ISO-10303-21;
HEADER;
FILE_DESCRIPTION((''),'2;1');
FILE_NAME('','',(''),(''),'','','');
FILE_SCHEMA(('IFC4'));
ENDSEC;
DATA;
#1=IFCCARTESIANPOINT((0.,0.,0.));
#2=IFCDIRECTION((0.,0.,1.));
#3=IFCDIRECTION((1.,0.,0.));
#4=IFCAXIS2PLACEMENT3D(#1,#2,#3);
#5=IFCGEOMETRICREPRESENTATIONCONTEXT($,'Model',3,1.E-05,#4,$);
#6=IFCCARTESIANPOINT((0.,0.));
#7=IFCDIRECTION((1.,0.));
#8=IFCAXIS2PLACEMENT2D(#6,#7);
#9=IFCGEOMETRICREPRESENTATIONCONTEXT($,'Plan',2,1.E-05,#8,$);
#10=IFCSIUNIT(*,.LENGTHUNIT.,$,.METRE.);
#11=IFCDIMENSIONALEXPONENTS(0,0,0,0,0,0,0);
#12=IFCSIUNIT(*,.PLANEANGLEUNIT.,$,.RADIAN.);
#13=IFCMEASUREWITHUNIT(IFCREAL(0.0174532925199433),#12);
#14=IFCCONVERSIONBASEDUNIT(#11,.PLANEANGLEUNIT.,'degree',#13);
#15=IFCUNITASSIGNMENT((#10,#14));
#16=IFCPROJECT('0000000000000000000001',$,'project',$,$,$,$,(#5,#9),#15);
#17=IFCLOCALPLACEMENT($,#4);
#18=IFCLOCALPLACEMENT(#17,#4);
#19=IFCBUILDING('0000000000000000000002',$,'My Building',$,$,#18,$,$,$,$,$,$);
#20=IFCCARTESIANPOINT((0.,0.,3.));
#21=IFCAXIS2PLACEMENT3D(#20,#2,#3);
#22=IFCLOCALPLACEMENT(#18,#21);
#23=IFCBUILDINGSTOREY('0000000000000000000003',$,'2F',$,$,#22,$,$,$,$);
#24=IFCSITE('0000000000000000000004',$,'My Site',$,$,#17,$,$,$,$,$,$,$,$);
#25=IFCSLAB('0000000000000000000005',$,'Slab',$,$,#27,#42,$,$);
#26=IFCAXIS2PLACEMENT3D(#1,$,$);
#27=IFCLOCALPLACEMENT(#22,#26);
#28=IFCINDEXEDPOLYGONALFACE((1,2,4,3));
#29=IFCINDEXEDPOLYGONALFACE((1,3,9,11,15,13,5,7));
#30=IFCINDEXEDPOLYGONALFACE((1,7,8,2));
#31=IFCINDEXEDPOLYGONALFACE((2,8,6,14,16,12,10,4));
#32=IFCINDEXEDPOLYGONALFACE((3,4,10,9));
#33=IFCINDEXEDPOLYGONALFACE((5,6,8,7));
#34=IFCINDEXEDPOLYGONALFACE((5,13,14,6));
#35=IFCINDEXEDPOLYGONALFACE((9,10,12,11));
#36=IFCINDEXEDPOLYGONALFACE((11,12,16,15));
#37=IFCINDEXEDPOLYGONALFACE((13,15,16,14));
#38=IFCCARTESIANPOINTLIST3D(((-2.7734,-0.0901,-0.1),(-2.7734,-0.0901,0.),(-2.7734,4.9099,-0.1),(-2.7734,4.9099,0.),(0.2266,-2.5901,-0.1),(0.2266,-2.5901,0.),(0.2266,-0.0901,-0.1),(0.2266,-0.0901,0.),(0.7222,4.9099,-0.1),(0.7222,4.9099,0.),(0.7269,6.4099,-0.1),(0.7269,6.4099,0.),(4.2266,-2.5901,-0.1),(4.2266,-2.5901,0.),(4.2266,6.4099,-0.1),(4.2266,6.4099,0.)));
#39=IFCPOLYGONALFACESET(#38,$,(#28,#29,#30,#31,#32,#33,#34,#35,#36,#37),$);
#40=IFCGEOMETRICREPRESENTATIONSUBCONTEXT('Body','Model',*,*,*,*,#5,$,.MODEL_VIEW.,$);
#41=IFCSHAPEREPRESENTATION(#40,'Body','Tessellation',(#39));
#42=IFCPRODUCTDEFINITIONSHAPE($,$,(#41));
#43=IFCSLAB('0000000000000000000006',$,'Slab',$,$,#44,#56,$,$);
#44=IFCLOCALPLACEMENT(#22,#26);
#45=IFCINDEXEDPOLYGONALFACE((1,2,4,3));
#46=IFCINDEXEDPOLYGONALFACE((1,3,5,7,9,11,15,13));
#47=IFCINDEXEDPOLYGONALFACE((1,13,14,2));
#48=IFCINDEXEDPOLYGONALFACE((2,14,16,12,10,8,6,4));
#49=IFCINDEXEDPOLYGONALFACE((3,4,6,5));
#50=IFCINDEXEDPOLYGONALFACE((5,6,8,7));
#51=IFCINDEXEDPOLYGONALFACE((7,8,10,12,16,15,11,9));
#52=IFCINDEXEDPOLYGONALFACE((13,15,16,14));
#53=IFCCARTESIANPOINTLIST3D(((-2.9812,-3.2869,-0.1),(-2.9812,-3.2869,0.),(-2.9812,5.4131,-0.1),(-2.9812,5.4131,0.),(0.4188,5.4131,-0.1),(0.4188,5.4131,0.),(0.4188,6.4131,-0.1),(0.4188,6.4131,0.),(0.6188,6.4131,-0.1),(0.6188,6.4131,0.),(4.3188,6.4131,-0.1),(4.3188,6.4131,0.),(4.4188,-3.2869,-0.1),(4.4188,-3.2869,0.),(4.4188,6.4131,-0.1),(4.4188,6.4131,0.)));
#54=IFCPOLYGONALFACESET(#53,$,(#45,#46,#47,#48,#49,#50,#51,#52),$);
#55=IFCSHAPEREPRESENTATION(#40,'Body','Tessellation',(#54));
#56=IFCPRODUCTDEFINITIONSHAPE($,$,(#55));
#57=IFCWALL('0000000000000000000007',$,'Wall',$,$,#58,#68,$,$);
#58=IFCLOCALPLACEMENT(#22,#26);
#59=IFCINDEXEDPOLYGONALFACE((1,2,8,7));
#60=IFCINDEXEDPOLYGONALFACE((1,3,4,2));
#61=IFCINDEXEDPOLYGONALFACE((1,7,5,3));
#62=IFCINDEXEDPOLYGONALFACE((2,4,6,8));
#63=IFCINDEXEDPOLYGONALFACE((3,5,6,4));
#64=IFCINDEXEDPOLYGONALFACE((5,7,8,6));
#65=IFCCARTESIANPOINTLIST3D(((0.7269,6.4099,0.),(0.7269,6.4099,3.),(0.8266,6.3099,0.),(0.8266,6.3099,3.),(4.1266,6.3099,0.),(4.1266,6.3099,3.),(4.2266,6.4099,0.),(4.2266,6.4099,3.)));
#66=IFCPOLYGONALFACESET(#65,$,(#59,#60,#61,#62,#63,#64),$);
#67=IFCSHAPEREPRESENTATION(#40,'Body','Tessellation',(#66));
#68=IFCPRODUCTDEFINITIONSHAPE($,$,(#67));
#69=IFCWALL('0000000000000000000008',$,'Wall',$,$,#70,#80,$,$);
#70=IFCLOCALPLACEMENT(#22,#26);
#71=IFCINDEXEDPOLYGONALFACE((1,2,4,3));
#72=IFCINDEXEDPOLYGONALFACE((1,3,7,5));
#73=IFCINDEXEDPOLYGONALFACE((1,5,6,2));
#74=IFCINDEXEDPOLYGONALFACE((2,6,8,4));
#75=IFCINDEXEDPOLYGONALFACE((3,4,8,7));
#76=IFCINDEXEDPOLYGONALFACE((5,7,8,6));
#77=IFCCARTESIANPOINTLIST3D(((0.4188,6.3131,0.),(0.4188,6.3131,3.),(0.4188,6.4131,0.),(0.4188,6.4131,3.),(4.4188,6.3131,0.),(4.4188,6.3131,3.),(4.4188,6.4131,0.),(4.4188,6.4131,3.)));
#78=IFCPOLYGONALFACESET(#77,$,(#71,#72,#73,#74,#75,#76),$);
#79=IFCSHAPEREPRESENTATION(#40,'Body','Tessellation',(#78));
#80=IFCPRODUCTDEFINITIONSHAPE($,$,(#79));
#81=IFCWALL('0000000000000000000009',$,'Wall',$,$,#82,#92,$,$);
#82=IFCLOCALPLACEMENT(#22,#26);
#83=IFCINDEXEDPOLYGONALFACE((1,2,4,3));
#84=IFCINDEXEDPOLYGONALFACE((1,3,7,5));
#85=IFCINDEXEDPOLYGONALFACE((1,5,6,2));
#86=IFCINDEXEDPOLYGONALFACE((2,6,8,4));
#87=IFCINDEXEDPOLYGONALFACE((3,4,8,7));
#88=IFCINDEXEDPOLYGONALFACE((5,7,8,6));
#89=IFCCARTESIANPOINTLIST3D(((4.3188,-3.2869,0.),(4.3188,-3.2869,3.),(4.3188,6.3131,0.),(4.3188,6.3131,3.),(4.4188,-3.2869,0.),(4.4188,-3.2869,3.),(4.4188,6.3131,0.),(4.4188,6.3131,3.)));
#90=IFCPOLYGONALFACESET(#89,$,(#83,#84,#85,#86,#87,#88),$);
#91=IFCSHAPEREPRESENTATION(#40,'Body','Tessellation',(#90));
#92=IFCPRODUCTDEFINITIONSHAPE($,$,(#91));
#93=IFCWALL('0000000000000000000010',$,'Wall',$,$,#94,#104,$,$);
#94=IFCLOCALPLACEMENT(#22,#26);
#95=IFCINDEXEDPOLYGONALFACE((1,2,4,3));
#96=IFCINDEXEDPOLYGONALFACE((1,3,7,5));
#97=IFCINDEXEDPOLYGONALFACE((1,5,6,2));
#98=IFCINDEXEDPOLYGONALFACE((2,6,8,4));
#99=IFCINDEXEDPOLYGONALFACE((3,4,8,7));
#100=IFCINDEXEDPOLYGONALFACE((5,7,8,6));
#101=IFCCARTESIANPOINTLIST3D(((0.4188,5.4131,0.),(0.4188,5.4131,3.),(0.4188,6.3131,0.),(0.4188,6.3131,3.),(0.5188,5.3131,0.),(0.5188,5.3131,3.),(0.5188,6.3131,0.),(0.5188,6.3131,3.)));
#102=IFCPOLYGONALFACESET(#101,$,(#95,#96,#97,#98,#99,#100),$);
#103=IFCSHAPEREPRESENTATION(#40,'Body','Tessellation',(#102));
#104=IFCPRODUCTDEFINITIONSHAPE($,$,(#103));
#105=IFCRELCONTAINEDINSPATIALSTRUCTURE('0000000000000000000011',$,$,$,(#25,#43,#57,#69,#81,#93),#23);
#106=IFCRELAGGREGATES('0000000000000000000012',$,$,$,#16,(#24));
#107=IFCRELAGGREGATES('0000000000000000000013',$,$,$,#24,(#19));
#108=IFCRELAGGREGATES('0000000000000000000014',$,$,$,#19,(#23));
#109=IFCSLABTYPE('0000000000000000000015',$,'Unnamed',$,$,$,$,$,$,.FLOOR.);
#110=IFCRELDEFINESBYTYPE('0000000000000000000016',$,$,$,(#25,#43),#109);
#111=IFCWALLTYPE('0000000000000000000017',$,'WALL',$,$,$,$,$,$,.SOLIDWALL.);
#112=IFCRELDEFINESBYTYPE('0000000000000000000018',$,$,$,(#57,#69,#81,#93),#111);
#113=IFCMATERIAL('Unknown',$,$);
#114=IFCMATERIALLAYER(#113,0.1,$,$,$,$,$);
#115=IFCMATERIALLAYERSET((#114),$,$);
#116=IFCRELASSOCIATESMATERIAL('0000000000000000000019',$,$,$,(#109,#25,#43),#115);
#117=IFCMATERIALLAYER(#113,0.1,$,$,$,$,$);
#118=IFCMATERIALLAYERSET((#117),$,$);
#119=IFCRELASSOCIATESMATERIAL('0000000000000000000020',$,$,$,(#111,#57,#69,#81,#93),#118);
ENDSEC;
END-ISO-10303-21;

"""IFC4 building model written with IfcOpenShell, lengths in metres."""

from ifc_helpers import new_model, entity, si_unit, converted_unit, frame, origin_with_axes, origin_2d_with_axis, place, context, subcontext, project, spatial, line, indexed_curve, outline, extrude, material, layer, layer_set, layer_usage, type_object, element, save


model = new_model("IFC4")

# Units and contexts
model_context = context("Model", 3, precision=1e-05, world=origin_with_axes())
plan_context = context("Plan", 2, precision=1e-05, world=origin_2d_with_axis())
body_context_1 = subcontext(model_context, "Body", "Model", "MODEL_VIEW")
ifc_project = project(units=[si_unit("LENGTHUNIT", "METRE"), converted_unit("PLANEANGLEUNIT", "degree", entity("IfcReal", 0.0174532925199433), si_unit("PLANEANGLEUNIT", "RADIAN"), dimensions=[0, 0, 0, 0, 0, 0, 0])], contexts=[model_context, plan_context])

# Site, building, storey
site_placement = place(None, origin_with_axes())
site = spatial("IfcSite", under=ifc_project, at=site_placement, Name="My Site")
building_placement = place(site_placement, origin_with_axes())
building = spatial("IfcBuilding", under=site, at=building_placement, Name="My Building")
storey_placement = place(building_placement, frame((0.0, 0.0, 3.0), z_axis=(0.0, 0.0, 1.0), x_axis=(1.0, 0.0, 0.0)))
storey = spatial("IfcBuildingStorey", under=building, at=storey_placement, Name="2F")

# Slabs
ifc_material = material(Name="Unknown")
ifc_layer_1 = layer(ifc_material, 0.1)
ifc_layer_set_1 = layer_set([ifc_layer_1])
ifc_layer_usage_1 = layer_usage(ifc_layer_set_1, "AXIS3", "POSITIVE", -0.1)
slab_type = type_object("IfcSlabType", Name="Unnamed", PredefinedType="FLOOR", material=ifc_layer_set_1)
slab_1_placement = place(storey_placement, frame((-2.7734, 4.9099, 0.0), z_axis=(0.0, 0.0, 1.0), x_axis=(1.0, 0.0, 0.0)))
element("IfcSlab", 1, at=slab_1_placement, inside=storey, type_object=slab_type, material=ifc_layer_usage_1, Name="Slab", context=body_context_1, shape_type="SweptSolid", body=[
    extrude(outline(indexed_curve([(0.0, 0.0), (3.4956, 0.0), (3.5003, 1.5), (7.0, 1.5), (7.0, -7.5), (3.0, -7.5), (3.0, -5.0), (0.0, -5.0), (0.0, 0.0)])), frame((0.0, 0.0, -0.1), z_axis=(0.0, 0.0, 1.0), x_axis=(1.0, 0.0, 0.0)), (0.0, 0.0, 1.0), 0.1),
])
ifc_layer_usage_2 = layer_usage(ifc_layer_set_1, "AXIS3", "POSITIVE", -0.1)
slab_2_placement = place(storey_placement, frame((0.6188, 6.4131, 0.0), z_axis=(0.0, 0.0, 1.0), x_axis=(1.0, 0.0, 0.0)))
element("IfcSlab", 2, at=slab_2_placement, inside=storey, type_object=slab_type, material=ifc_layer_usage_2, Name="Slab", context=body_context_1, shape_type="SweptSolid", body=[
    extrude(outline(indexed_curve([(0.0, 0.0), (3.7, 0.0), (3.8, 0.0), (3.8, -9.7), (-3.6, -9.7), (-3.6, -1.0), (-0.2, -1.0), (-0.2, 0.0), (0.0, 0.0)])), frame((0.0, 0.0, -0.1), z_axis=(0.0, 0.0, 1.0), x_axis=(1.0, 0.0, 0.0)), (0.0, 0.0, 1.0), 0.1),
])

# Walls
ifc_layer_2 = layer(ifc_material, 0.1)
ifc_layer_set_2 = layer_set([ifc_layer_2])
ifc_layer_usage_3 = layer_usage(ifc_layer_set_2, "AXIS2", "POSITIVE", 0.0)
wall_type = type_object("IfcWallType", Name="WALL", PredefinedType="SOLIDWALL", material=ifc_layer_set_2)
wall_1_placement = place(storey_placement, frame((0.8266, 6.3099, 0.0), z_axis=(0.0, 0.0, 1.0), x_axis=(1.0, 0.0, 0.0)))
element("IfcWall", 3, at=wall_1_placement, inside=storey, type_object=wall_type, material=ifc_layer_usage_3, Name="Wall", context=body_context_1, shape_type="SweptSolid", body=[
    extrude(outline(indexed_curve([(0.0, 0.0), (-0.0997, 0.1), (3.4, 0.1), (3.3, 0.0)], segments=[line(1, 2, 3, 4, 1)])), origin_with_axes(), (0.0, 0.0, 1.0), 3.0),
])
ifc_layer_usage_4 = layer_usage(ifc_layer_set_2, "AXIS2", "POSITIVE", 0.0)
wall_2_placement = place(storey_placement, frame((0.4188, 6.3131, 0.0), z_axis=(0.0, 0.0, 1.0), x_axis=(1.0, 0.0, 0.0)))
element("IfcWall", 4, at=wall_2_placement, inside=storey, type_object=wall_type, material=ifc_layer_usage_4, Name="Wall", context=body_context_1, shape_type="SweptSolid", body=[
    extrude(outline(indexed_curve([(0.0, 0.0), (0.0, 0.1), (4.0, 0.1), (4.0, 0.0)], segments=[line(1, 2, 3, 4, 1)])), origin_with_axes(), (0.0, 0.0, 1.0), 3.0),
])
ifc_layer_usage_5 = layer_usage(ifc_layer_set_2, "AXIS2", "POSITIVE", 0.0)
wall_3_placement = place(storey_placement, frame((4.3188, 6.3131, 0.0), z_axis=(0.0, 0.0, 1.0), x_axis=(0.0, -1.0, 0.0)))
element("IfcWall", 5, at=wall_3_placement, inside=storey, type_object=wall_type, material=ifc_layer_usage_5, Name="Wall", context=body_context_1, shape_type="SweptSolid", body=[
    extrude(outline(indexed_curve([(0.0, 0.0), (0.0, 0.1), (9.6, 0.1), (9.6, 0.0)], segments=[line(1, 2, 3, 4, 1)])), origin_with_axes(), (0.0, 0.0, 1.0), 3.0),
])
ifc_layer_usage_6 = layer_usage(ifc_layer_set_2, "AXIS2", "POSITIVE", 0.0)
wall_4_placement = place(storey_placement, frame((0.4188, 6.3131, 0.0), z_axis=(0.0, 0.0, 1.0), x_axis=(0.0, -1.0, 0.0)))
element("IfcWall", 6, at=wall_4_placement, inside=storey, type_object=wall_type, material=ifc_layer_usage_6, Name="Wall", context=body_context_1, shape_type="SweptSolid", body=[
    extrude(outline(indexed_curve([(0.0, 0.0), (0.0, 0.1), (1.0, 0.1), (0.9, 0.0)], segments=[line(1, 2, 3, 4, 1)])), origin_with_axes(), (0.0, 0.0, 1.0), 3.0),
])

save(model, "model.ifc")
